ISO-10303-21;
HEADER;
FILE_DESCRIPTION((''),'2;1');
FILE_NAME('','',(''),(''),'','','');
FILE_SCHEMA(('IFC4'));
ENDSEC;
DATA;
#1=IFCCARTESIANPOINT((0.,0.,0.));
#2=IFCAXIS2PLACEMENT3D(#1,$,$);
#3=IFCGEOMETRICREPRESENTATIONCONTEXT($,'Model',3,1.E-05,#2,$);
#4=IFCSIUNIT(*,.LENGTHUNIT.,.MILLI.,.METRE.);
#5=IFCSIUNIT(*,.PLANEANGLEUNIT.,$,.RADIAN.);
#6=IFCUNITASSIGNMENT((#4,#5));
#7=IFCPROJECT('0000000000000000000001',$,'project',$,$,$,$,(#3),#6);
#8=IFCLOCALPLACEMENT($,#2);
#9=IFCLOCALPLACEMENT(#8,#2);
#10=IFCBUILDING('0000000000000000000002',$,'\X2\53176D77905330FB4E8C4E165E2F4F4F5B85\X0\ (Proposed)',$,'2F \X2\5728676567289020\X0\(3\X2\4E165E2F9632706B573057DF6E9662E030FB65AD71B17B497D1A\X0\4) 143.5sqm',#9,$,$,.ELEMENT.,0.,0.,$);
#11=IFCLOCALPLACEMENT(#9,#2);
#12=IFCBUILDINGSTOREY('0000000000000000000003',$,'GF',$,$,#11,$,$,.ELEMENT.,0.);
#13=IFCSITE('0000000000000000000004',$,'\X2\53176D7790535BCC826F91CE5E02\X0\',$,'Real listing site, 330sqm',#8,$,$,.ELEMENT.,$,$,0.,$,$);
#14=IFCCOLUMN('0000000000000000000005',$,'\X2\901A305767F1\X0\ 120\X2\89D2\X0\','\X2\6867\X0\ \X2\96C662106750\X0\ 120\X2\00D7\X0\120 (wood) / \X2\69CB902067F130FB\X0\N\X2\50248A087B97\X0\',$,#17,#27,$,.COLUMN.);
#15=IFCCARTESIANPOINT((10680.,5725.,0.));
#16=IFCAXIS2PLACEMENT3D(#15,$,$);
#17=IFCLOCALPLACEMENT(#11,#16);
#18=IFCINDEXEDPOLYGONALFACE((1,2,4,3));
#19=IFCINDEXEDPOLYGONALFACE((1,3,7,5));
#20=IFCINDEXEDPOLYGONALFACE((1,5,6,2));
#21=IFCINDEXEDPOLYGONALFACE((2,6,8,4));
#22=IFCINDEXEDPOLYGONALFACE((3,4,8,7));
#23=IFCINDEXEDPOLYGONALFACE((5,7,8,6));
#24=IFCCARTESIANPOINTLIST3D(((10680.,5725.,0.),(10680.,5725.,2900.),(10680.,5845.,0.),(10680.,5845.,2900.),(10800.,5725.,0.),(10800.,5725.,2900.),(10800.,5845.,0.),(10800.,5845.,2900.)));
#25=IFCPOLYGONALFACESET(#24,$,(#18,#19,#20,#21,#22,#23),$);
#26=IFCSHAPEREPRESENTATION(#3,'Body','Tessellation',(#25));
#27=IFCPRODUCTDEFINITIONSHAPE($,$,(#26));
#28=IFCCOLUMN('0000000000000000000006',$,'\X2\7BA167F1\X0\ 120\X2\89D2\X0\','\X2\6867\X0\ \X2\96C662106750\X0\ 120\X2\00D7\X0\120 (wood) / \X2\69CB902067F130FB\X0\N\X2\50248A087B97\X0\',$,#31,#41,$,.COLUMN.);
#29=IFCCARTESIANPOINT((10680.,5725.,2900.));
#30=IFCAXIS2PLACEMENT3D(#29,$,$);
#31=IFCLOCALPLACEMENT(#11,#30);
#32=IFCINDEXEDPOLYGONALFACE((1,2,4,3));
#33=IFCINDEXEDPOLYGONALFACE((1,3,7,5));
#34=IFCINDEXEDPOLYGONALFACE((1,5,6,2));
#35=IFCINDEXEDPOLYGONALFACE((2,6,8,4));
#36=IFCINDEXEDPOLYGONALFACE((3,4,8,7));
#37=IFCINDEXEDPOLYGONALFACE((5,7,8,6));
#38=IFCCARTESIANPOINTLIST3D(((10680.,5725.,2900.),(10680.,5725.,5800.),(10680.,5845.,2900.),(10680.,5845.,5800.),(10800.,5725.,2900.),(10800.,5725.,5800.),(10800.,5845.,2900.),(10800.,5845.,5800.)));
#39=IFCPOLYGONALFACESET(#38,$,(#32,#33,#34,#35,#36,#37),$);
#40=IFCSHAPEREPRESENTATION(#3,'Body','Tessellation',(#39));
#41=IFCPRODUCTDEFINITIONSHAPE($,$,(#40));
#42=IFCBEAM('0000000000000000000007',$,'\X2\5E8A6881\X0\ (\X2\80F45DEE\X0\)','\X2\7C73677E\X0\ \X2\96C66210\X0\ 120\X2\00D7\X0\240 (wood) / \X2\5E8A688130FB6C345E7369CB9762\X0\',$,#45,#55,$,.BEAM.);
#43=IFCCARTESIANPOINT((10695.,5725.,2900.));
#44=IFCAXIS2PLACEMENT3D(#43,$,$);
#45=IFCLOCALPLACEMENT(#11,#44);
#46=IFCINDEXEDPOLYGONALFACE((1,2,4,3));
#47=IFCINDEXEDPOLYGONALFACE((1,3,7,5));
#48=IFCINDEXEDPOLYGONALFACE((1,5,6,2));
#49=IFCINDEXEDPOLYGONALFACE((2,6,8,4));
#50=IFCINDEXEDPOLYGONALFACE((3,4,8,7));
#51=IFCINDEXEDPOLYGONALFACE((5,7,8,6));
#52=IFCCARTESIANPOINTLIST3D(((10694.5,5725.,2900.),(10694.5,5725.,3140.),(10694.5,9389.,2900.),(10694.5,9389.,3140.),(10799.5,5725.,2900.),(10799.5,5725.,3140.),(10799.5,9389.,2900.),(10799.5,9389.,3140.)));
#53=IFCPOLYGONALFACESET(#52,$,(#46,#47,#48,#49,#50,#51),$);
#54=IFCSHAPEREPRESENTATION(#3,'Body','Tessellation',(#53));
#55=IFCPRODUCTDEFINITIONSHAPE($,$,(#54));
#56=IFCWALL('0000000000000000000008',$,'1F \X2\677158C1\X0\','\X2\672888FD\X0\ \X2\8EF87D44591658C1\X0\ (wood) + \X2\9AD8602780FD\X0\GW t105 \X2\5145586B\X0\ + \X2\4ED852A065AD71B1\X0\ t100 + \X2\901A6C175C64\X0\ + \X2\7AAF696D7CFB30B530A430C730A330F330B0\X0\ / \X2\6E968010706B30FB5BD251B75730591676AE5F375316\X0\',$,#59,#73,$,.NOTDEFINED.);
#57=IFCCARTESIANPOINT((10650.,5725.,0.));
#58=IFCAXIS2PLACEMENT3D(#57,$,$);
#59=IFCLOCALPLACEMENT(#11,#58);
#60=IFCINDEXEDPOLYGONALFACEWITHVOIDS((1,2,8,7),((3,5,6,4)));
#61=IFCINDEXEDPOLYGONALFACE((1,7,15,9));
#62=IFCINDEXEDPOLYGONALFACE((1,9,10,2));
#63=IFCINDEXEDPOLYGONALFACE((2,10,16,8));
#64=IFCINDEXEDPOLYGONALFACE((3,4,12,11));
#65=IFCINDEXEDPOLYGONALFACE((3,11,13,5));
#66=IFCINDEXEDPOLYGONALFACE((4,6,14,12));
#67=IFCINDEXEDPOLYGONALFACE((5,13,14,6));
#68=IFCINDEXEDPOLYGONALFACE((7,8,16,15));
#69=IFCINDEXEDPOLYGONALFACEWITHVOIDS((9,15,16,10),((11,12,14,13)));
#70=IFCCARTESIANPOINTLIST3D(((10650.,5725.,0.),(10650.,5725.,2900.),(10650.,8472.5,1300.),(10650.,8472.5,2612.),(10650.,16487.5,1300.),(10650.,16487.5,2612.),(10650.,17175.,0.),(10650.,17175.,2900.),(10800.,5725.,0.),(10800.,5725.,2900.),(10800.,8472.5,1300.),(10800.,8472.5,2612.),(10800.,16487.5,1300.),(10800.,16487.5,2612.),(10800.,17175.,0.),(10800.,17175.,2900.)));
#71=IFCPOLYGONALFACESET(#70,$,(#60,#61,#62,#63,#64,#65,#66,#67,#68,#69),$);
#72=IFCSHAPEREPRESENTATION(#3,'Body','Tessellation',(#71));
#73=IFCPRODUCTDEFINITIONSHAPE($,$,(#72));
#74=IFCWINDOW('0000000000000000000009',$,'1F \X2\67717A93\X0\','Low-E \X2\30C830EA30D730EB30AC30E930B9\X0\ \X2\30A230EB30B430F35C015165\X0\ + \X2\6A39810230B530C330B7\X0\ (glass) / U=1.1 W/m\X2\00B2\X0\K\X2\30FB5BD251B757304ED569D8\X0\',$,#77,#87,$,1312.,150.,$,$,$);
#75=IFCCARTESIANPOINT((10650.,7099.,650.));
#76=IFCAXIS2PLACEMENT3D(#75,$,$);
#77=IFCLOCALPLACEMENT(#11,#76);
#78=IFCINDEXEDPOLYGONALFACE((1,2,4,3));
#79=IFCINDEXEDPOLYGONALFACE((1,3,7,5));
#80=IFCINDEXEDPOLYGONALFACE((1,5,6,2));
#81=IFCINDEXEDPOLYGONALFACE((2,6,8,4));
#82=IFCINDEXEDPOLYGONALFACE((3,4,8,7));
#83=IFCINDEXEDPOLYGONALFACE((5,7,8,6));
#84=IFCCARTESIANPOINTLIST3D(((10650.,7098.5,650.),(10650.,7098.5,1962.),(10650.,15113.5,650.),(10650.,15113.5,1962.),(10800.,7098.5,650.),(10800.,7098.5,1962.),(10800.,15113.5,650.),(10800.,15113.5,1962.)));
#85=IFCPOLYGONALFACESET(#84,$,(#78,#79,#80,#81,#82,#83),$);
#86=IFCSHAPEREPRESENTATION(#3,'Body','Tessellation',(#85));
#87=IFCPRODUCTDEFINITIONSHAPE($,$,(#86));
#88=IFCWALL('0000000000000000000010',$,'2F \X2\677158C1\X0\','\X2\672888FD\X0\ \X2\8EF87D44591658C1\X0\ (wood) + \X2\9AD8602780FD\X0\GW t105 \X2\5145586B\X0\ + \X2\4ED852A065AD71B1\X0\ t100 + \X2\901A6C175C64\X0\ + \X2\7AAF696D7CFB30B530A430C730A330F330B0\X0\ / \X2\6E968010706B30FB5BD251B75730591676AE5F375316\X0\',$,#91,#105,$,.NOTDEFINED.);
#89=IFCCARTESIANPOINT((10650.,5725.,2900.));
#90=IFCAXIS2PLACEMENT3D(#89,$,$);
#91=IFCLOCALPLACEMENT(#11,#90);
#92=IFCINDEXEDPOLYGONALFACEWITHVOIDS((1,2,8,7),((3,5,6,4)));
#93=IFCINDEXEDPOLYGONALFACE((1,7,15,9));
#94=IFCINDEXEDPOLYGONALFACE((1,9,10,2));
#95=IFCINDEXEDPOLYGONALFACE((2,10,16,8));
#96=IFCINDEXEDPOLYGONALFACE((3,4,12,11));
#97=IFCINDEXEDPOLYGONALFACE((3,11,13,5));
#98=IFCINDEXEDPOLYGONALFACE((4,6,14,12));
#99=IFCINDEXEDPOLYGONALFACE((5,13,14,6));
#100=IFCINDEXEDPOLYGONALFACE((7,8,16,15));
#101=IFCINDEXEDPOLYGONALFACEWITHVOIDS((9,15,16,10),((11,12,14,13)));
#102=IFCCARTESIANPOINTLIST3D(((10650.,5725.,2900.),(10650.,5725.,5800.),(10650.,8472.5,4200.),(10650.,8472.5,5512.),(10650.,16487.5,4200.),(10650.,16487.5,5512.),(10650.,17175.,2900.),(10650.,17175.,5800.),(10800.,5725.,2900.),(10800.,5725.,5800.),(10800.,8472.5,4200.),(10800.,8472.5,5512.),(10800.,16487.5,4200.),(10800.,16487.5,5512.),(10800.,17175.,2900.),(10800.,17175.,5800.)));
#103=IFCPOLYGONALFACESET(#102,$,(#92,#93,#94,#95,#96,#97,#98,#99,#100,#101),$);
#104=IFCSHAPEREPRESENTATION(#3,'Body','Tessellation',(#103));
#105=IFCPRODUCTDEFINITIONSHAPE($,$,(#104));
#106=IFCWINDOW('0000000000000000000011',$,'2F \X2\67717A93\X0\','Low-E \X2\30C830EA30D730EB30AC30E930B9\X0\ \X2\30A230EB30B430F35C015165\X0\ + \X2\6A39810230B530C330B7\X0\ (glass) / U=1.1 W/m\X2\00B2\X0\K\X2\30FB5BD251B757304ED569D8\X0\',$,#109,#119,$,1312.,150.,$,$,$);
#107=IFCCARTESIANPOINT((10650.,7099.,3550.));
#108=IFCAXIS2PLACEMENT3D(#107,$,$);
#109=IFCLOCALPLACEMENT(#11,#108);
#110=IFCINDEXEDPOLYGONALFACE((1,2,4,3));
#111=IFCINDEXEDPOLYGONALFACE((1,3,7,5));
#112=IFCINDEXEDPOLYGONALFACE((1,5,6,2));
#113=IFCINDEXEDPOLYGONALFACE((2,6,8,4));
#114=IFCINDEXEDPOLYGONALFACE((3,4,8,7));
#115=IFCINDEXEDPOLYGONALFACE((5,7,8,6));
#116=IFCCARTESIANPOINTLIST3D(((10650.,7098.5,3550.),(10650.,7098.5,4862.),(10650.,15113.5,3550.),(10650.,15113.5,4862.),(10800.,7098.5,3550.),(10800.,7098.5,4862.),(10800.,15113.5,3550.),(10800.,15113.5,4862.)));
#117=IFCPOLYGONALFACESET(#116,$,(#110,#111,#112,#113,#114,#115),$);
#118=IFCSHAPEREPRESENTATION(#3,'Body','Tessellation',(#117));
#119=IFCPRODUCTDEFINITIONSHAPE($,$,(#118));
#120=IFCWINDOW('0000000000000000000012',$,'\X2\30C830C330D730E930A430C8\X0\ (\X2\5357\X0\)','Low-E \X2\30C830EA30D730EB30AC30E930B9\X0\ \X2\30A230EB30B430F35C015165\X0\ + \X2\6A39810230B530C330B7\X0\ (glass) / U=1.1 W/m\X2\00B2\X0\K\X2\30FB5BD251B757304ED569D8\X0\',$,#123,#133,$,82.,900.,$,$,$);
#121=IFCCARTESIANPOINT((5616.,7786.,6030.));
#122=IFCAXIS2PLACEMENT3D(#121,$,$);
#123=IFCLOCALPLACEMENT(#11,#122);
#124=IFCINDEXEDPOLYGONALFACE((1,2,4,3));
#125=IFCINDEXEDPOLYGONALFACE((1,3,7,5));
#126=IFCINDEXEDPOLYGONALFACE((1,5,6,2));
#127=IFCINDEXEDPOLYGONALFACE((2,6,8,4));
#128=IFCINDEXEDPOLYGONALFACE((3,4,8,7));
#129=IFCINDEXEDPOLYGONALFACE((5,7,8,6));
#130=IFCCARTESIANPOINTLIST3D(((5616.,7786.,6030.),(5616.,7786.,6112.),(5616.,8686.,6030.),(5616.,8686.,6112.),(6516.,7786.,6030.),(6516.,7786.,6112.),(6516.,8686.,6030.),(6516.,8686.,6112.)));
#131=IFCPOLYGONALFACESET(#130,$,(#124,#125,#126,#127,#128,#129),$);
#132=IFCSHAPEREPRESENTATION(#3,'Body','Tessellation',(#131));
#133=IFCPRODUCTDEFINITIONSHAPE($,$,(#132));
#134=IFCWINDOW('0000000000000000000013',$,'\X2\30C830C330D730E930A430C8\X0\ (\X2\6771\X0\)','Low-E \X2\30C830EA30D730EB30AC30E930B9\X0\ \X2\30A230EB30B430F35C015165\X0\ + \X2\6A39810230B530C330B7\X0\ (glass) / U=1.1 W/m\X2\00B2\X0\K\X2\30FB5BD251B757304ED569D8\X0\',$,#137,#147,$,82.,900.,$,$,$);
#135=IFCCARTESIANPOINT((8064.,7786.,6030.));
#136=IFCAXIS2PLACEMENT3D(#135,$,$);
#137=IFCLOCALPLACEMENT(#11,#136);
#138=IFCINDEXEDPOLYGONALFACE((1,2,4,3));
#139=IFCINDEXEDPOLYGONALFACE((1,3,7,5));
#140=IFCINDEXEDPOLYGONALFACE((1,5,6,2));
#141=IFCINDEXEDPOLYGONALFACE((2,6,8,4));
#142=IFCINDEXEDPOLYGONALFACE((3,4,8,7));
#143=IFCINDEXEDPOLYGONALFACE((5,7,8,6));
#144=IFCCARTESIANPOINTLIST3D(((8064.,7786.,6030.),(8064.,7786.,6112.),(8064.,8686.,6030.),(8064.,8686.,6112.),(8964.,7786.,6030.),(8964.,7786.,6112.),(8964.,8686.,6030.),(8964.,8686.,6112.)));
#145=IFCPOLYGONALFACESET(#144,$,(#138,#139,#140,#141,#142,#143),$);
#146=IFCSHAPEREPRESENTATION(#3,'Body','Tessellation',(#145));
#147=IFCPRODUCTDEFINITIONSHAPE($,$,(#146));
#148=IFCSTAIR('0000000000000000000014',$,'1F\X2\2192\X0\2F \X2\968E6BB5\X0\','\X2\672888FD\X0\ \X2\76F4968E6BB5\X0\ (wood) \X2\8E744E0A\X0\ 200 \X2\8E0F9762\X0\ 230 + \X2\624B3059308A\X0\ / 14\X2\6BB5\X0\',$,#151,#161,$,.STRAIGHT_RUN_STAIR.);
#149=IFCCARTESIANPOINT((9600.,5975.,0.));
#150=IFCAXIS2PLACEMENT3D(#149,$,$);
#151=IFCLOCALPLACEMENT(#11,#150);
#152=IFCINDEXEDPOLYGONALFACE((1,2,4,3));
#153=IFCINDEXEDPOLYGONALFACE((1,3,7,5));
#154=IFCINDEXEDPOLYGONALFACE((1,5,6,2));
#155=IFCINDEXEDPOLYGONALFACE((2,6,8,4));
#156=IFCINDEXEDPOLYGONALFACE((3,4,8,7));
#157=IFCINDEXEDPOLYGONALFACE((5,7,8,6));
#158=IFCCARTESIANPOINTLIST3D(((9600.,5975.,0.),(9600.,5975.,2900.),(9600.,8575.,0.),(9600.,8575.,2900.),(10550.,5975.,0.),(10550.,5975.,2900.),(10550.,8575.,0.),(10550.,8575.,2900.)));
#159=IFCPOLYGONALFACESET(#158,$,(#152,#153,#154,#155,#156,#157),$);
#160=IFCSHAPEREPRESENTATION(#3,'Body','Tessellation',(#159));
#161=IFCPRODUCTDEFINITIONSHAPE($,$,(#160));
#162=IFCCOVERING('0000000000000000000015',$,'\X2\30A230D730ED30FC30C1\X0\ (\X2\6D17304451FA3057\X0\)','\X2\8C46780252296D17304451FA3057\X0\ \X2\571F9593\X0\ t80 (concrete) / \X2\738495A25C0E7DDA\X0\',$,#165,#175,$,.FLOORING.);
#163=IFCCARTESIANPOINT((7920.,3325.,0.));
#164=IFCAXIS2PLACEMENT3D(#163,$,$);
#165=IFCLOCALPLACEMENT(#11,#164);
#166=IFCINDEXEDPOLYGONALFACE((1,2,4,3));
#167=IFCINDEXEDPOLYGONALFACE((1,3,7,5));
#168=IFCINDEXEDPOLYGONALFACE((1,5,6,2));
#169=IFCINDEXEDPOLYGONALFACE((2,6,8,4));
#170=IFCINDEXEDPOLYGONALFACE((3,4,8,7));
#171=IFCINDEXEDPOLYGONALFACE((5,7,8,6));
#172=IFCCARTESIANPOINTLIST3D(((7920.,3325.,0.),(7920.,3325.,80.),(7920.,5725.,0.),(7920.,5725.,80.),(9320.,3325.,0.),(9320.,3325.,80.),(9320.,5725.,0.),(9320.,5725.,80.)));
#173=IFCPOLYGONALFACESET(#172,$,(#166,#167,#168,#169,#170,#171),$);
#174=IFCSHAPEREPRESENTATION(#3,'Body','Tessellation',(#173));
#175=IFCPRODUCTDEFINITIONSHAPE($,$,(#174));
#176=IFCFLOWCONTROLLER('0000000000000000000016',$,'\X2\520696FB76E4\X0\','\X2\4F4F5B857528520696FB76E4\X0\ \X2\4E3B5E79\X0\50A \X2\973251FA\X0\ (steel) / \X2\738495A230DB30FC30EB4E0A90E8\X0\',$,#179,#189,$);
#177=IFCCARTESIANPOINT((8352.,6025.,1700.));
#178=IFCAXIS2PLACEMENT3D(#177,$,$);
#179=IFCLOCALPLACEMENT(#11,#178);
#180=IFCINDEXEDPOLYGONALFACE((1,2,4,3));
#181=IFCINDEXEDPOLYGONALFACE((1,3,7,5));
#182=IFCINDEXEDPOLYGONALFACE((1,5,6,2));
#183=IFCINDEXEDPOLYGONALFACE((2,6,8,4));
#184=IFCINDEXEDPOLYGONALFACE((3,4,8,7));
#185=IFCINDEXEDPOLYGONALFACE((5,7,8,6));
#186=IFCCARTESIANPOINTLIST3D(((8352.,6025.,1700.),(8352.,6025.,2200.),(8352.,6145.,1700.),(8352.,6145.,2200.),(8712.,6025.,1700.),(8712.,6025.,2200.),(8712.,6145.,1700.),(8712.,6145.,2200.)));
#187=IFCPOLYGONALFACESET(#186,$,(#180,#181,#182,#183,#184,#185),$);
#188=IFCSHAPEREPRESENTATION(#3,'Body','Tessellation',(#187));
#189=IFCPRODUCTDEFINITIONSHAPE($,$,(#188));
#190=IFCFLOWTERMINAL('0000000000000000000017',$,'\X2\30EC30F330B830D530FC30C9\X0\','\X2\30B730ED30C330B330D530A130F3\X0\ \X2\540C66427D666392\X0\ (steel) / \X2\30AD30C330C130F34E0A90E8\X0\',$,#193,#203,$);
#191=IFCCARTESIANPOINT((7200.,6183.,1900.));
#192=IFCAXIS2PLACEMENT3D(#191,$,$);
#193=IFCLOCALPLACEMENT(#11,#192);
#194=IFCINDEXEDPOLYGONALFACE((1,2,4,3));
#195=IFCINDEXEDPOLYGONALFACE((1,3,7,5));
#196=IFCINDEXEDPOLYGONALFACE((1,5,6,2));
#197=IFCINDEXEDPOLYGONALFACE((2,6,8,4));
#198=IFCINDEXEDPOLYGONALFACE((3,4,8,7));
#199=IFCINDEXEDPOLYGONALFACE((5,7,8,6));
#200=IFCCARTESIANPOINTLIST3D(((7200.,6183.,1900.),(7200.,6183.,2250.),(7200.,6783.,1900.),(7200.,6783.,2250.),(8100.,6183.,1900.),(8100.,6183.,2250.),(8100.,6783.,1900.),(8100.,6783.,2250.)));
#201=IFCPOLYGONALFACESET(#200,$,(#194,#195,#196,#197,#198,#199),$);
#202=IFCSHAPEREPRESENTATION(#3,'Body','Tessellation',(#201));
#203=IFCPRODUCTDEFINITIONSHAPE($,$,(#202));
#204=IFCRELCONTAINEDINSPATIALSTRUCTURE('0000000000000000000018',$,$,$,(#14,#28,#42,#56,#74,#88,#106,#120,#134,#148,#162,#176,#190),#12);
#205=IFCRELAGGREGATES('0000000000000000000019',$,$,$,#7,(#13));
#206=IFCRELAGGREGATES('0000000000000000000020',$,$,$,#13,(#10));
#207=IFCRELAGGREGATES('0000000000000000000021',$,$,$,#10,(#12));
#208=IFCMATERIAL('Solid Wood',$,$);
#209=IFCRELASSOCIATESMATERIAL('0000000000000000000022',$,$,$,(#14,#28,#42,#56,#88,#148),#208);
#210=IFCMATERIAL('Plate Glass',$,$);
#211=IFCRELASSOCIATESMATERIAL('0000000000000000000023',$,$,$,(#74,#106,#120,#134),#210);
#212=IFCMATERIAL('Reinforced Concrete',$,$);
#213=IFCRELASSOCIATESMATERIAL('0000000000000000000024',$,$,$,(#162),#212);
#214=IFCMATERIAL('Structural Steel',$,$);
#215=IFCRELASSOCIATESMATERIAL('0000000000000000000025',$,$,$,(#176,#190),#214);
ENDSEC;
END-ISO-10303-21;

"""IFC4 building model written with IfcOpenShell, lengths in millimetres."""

from ifc_helpers import new_model, si_unit, frame, frame_2d, origin, place, context, project, spatial, rectangle, extrude, material, element, fill, save


model = new_model("IFC4")

# Units and contexts
model_context = context("Model", 3, precision=1e-05, world=origin())
ifc_project = project(units=[si_unit("LENGTHUNIT", "METRE", prefix="MILLI"), si_unit("PLANEANGLEUNIT", "RADIAN")], contexts=[model_context])

# Site, building, storey
site_placement = place(None, origin())
site = spatial("IfcSite", under=ifc_project, at=site_placement, Name="北海道富良野市", ObjectType="Real listing site, 330sqm", CompositionType="ELEMENT", RefElevation=0.0)
building_placement = place(site_placement, origin())
building = spatial("IfcBuilding", under=site, at=building_placement, Name="北海道・二世帯住宅 (Proposed)", ObjectType="2F 在来木造(3世帯防火地域準拠・断熱等級4) 143.5sqm", CompositionType="ELEMENT", ElevationOfRefHeight=0.0, ElevationOfTerrain=0.0)
storey_placement = place(building_placement, origin())
storey = spatial("IfcBuildingStorey", under=building, at=storey_placement, Name="GF", CompositionType="ELEMENT", Elevation=0.0)

# Columns
ifc_material_1 = material(Name="Solid Wood")
column_1_placement = place(storey_placement, frame((10680.0, 5725.0, 0.0)))
element("IfcColumn", 1, at=column_1_placement, inside=storey, material=ifc_material_1, Name="通し柱 120角", Description="桧 集成材 120×120 (wood) / 構造柱・N値計算", PredefinedType="COLUMN", context=model_context, shape_type="SweptSolid", body=[
    extrude(rectangle(XDim=120.0, YDim=120.0, at=frame_2d((60.0, 60.0))), frame((10680.0, 5725.0, 0.0)), (0.0, 0.0, 1.0), 2900.0),
])
column_2_placement = place(storey_placement, frame((10680.0, 5725.0, 2900.0)))
element("IfcColumn", 2, at=column_2_placement, inside=storey, material=ifc_material_1, Name="管柱 120角", Description="桧 集成材 120×120 (wood) / 構造柱・N値計算", PredefinedType="COLUMN", context=model_context, shape_type="SweptSolid", body=[
    extrude(rectangle(XDim=120.0, YDim=120.0, at=frame_2d((60.0, 60.0))), frame((10680.0, 5725.0, 2900.0)), (0.0, 0.0, 1.0), 2900.0),
])

# Beam
beam_1_placement = place(storey_placement, frame((10695.0, 5725.0, 2900.0)))
element("IfcBeam", 3, at=beam_1_placement, inside=storey, material=ifc_material_1, Name="床梁 (胴差)", Description="米松 集成 120×240 (wood) / 床梁・水平構面", PredefinedType="BEAM", context=model_context, shape_type="SweptSolid", body=[
    extrude(rectangle(XDim=105.0, YDim=3664.0, at=frame_2d((52.0, 1832.0))), frame((10695.0, 5725.0, 2900.0)), (0.0, 0.0, 1.0), 240.0),
])

# Wall, opening, window
wall_1_placement = place(storey_placement, frame((10650.0, 5725.0, 0.0)))
wall_1 = element("IfcWall", 4, at=wall_1_placement, inside=storey, material=ifc_material_1, Name="1F 東壁", Description="木製 軸組外壁 (wood) + 高性能GW t105 充填 + 付加断熱 t100 + 通気層 + 窯業系サイディング / 準耐火・寒冷地外皮強化", PredefinedType="NOTDEFINED", context=model_context, shape_type="SweptSolid", body=[
    extrude(rectangle(XDim=150.0, YDim=11450.0, at=frame_2d((75.0, 5725.0))), frame((10650.0, 5725.0, 0.0)), (0.0, 0.0, 1.0), 2900.0),
])
opening_1_placement = place(storey_placement, frame((10650.0, 7099.0, 650.0)))
opening_1 = element("IfcOpeningElement", 5, at=opening_1_placement, cuts=wall_1, PredefinedType="NOTDEFINED", context=model_context, shape_type="SweptSolid", body=[
    extrude(rectangle(XDim=150.0, YDim=8015.0, at=frame_2d((75.0, 4007.0))), frame((10650.0, 7099.0, 650.0)), (0.0, 0.0, 1.0), 1312.0),
])
ifc_material_2 = material(Name="Plate Glass")
window_1_placement = place(storey_placement, frame((10650.0, 7099.0, 650.0)))
window_1 = element("IfcWindow", 6, at=window_1_placement, inside=storey, material=ifc_material_2, Name="1F 東窓", Description="Low-E トリプルガラス アルゴン封入 + 樹脂サッシ (glass) / U=1.1 W/m²K・寒冷地仕様", OverallHeight=1312.0, OverallWidth=150.0, context=model_context, shape_type="SweptSolid", body=[
    extrude(rectangle(XDim=150.0, YDim=8015.0, at=frame_2d((75.0, 4007.0))), frame((10650.0, 7099.0, 650.0)), (0.0, 0.0, 1.0), 1312.0),
])
fill(opening_1, window_1)

# Wall, opening, window
wall_2_placement = place(storey_placement, frame((10650.0, 5725.0, 2900.0)))
wall_2 = element("IfcWall", 7, at=wall_2_placement, inside=storey, material=ifc_material_1, Name="2F 東壁", Description="木製 軸組外壁 (wood) + 高性能GW t105 充填 + 付加断熱 t100 + 通気層 + 窯業系サイディング / 準耐火・寒冷地外皮強化", PredefinedType="NOTDEFINED", context=model_context, shape_type="SweptSolid", body=[
    extrude(rectangle(XDim=150.0, YDim=11450.0, at=frame_2d((75.0, 5725.0))), frame((10650.0, 5725.0, 2900.0)), (0.0, 0.0, 1.0), 2900.0),
])
opening_2_placement = place(storey_placement, frame((10650.0, 7099.0, 3550.0)))
opening_2 = element("IfcOpeningElement", 8, at=opening_2_placement, cuts=wall_2, PredefinedType="NOTDEFINED", context=model_context, shape_type="SweptSolid", body=[
    extrude(rectangle(XDim=150.0, YDim=8015.0, at=frame_2d((75.0, 4007.0))), frame((10650.0, 7099.0, 3550.0)), (0.0, 0.0, 1.0), 1312.0),
])
window_2_placement = place(storey_placement, frame((10650.0, 7099.0, 3550.0)))
window_2 = element("IfcWindow", 9, at=window_2_placement, inside=storey, material=ifc_material_2, Name="2F 東窓", Description="Low-E トリプルガラス アルゴン封入 + 樹脂サッシ (glass) / U=1.1 W/m²K・寒冷地仕様", OverallHeight=1312.0, OverallWidth=150.0, context=model_context, shape_type="SweptSolid", body=[
    extrude(rectangle(XDim=150.0, YDim=8015.0, at=frame_2d((75.0, 4007.0))), frame((10650.0, 7099.0, 3550.0)), (0.0, 0.0, 1.0), 1312.0),
])
fill(opening_2, window_2)

# Windows
window_3_placement = place(storey_placement, frame((5616.0, 7786.0, 6030.0)))
element("IfcWindow", 10, at=window_3_placement, inside=storey, material=ifc_material_2, Name="トップライト (南)", Description="Low-E トリプルガラス アルゴン封入 + 樹脂サッシ (glass) / U=1.1 W/m²K・寒冷地仕様", OverallHeight=82.0, OverallWidth=900.0, context=model_context, shape_type="SweptSolid", body=[
    extrude(rectangle(XDim=900.0, YDim=900.0, at=frame_2d((450.0, 450.0))), frame((5616.0, 7786.0, 6030.0)), (0.0, 0.0, 1.0), 82.0),
])
window_4_placement = place(storey_placement, frame((8064.0, 7786.0, 6030.0)))
element("IfcWindow", 11, at=window_4_placement, inside=storey, material=ifc_material_2, Name="トップライト (東)", Description="Low-E トリプルガラス アルゴン封入 + 樹脂サッシ (glass) / U=1.1 W/m²K・寒冷地仕様", OverallHeight=82.0, OverallWidth=900.0, context=model_context, shape_type="SweptSolid", body=[
    extrude(rectangle(XDim=900.0, YDim=900.0, at=frame_2d((450.0, 450.0))), frame((8064.0, 7786.0, 6030.0)), (0.0, 0.0, 1.0), 82.0),
])

# Stair
stair_placement = place(storey_placement, frame((9600.0, 5975.0, 0.0)))
element("IfcStair", 12, at=stair_placement, inside=storey, material=ifc_material_1, Name="1F→2F 階段", Description="木製 直階段 (wood) 蹴上 200 踏面 230 + 手すり / 14段", PredefinedType="STRAIGHT_RUN_STAIR", context=model_context, shape_type="SweptSolid", body=[
    extrude(rectangle(XDim=950.0, YDim=2600.0, at=frame_2d((475.0, 1300.0))), frame((9600.0, 5975.0, 0.0)), (0.0, 0.0, 1.0), 2900.0),
])

# Covering
ifc_material_3 = material(Name="Reinforced Concrete")
covering_placement = place(storey_placement, frame((7920.0, 3325.0, 0.0)))
element("IfcCovering", 13, at=covering_placement, inside=storey, material=ifc_material_3, Name="アプローチ (洗い出し)", Description="豆砂利洗い出し 土間 t80 (concrete) / 玄関導線", PredefinedType="FLOORING", context=model_context, shape_type="SweptSolid", body=[
    extrude(rectangle(XDim=1400.0, YDim=2400.0, at=frame_2d((700.0, 1200.0))), frame((7920.0, 3325.0, 0.0)), (0.0, 0.0, 1.0), 80.0),
])

# Flow controller
ifc_material_4 = material(Name="Structural Steel")
flow_controller_placement = place(storey_placement, frame((8352.0, 6025.0, 1700.0)))
element("IfcFlowController", 14, at=flow_controller_placement, inside=storey, material=ifc_material_4, Name="分電盤", Description="住宅用分電盤 主幹50A 露出 (steel) / 玄関ホール上部", context=model_context, shape_type="SweptSolid", body=[
    extrude(rectangle(XDim=360.0, YDim=120.0, at=frame_2d((180.0, 60.0))), frame((8352.0, 6025.0, 1700.0)), (0.0, 0.0, 1.0), 500.0),
])

# Flow terminal
flow_terminal_1_placement = place(storey_placement, frame((7200.0, 6183.0, 1900.0)))
element("IfcFlowTerminal", 15, at=flow_terminal_1_placement, inside=storey, material=ifc_material_4, Name="レンジフード", Description="シロッコファン 同時給排 (steel) / キッチン上部", context=model_context, shape_type="SweptSolid", body=[
    extrude(rectangle(XDim=900.0, YDim=600.0, at=frame_2d((450.0, 300.0))), frame((7200.0, 6183.0, 1900.0)), (0.0, 0.0, 1.0), 350.0),
])

save(model, "model.ifc")
